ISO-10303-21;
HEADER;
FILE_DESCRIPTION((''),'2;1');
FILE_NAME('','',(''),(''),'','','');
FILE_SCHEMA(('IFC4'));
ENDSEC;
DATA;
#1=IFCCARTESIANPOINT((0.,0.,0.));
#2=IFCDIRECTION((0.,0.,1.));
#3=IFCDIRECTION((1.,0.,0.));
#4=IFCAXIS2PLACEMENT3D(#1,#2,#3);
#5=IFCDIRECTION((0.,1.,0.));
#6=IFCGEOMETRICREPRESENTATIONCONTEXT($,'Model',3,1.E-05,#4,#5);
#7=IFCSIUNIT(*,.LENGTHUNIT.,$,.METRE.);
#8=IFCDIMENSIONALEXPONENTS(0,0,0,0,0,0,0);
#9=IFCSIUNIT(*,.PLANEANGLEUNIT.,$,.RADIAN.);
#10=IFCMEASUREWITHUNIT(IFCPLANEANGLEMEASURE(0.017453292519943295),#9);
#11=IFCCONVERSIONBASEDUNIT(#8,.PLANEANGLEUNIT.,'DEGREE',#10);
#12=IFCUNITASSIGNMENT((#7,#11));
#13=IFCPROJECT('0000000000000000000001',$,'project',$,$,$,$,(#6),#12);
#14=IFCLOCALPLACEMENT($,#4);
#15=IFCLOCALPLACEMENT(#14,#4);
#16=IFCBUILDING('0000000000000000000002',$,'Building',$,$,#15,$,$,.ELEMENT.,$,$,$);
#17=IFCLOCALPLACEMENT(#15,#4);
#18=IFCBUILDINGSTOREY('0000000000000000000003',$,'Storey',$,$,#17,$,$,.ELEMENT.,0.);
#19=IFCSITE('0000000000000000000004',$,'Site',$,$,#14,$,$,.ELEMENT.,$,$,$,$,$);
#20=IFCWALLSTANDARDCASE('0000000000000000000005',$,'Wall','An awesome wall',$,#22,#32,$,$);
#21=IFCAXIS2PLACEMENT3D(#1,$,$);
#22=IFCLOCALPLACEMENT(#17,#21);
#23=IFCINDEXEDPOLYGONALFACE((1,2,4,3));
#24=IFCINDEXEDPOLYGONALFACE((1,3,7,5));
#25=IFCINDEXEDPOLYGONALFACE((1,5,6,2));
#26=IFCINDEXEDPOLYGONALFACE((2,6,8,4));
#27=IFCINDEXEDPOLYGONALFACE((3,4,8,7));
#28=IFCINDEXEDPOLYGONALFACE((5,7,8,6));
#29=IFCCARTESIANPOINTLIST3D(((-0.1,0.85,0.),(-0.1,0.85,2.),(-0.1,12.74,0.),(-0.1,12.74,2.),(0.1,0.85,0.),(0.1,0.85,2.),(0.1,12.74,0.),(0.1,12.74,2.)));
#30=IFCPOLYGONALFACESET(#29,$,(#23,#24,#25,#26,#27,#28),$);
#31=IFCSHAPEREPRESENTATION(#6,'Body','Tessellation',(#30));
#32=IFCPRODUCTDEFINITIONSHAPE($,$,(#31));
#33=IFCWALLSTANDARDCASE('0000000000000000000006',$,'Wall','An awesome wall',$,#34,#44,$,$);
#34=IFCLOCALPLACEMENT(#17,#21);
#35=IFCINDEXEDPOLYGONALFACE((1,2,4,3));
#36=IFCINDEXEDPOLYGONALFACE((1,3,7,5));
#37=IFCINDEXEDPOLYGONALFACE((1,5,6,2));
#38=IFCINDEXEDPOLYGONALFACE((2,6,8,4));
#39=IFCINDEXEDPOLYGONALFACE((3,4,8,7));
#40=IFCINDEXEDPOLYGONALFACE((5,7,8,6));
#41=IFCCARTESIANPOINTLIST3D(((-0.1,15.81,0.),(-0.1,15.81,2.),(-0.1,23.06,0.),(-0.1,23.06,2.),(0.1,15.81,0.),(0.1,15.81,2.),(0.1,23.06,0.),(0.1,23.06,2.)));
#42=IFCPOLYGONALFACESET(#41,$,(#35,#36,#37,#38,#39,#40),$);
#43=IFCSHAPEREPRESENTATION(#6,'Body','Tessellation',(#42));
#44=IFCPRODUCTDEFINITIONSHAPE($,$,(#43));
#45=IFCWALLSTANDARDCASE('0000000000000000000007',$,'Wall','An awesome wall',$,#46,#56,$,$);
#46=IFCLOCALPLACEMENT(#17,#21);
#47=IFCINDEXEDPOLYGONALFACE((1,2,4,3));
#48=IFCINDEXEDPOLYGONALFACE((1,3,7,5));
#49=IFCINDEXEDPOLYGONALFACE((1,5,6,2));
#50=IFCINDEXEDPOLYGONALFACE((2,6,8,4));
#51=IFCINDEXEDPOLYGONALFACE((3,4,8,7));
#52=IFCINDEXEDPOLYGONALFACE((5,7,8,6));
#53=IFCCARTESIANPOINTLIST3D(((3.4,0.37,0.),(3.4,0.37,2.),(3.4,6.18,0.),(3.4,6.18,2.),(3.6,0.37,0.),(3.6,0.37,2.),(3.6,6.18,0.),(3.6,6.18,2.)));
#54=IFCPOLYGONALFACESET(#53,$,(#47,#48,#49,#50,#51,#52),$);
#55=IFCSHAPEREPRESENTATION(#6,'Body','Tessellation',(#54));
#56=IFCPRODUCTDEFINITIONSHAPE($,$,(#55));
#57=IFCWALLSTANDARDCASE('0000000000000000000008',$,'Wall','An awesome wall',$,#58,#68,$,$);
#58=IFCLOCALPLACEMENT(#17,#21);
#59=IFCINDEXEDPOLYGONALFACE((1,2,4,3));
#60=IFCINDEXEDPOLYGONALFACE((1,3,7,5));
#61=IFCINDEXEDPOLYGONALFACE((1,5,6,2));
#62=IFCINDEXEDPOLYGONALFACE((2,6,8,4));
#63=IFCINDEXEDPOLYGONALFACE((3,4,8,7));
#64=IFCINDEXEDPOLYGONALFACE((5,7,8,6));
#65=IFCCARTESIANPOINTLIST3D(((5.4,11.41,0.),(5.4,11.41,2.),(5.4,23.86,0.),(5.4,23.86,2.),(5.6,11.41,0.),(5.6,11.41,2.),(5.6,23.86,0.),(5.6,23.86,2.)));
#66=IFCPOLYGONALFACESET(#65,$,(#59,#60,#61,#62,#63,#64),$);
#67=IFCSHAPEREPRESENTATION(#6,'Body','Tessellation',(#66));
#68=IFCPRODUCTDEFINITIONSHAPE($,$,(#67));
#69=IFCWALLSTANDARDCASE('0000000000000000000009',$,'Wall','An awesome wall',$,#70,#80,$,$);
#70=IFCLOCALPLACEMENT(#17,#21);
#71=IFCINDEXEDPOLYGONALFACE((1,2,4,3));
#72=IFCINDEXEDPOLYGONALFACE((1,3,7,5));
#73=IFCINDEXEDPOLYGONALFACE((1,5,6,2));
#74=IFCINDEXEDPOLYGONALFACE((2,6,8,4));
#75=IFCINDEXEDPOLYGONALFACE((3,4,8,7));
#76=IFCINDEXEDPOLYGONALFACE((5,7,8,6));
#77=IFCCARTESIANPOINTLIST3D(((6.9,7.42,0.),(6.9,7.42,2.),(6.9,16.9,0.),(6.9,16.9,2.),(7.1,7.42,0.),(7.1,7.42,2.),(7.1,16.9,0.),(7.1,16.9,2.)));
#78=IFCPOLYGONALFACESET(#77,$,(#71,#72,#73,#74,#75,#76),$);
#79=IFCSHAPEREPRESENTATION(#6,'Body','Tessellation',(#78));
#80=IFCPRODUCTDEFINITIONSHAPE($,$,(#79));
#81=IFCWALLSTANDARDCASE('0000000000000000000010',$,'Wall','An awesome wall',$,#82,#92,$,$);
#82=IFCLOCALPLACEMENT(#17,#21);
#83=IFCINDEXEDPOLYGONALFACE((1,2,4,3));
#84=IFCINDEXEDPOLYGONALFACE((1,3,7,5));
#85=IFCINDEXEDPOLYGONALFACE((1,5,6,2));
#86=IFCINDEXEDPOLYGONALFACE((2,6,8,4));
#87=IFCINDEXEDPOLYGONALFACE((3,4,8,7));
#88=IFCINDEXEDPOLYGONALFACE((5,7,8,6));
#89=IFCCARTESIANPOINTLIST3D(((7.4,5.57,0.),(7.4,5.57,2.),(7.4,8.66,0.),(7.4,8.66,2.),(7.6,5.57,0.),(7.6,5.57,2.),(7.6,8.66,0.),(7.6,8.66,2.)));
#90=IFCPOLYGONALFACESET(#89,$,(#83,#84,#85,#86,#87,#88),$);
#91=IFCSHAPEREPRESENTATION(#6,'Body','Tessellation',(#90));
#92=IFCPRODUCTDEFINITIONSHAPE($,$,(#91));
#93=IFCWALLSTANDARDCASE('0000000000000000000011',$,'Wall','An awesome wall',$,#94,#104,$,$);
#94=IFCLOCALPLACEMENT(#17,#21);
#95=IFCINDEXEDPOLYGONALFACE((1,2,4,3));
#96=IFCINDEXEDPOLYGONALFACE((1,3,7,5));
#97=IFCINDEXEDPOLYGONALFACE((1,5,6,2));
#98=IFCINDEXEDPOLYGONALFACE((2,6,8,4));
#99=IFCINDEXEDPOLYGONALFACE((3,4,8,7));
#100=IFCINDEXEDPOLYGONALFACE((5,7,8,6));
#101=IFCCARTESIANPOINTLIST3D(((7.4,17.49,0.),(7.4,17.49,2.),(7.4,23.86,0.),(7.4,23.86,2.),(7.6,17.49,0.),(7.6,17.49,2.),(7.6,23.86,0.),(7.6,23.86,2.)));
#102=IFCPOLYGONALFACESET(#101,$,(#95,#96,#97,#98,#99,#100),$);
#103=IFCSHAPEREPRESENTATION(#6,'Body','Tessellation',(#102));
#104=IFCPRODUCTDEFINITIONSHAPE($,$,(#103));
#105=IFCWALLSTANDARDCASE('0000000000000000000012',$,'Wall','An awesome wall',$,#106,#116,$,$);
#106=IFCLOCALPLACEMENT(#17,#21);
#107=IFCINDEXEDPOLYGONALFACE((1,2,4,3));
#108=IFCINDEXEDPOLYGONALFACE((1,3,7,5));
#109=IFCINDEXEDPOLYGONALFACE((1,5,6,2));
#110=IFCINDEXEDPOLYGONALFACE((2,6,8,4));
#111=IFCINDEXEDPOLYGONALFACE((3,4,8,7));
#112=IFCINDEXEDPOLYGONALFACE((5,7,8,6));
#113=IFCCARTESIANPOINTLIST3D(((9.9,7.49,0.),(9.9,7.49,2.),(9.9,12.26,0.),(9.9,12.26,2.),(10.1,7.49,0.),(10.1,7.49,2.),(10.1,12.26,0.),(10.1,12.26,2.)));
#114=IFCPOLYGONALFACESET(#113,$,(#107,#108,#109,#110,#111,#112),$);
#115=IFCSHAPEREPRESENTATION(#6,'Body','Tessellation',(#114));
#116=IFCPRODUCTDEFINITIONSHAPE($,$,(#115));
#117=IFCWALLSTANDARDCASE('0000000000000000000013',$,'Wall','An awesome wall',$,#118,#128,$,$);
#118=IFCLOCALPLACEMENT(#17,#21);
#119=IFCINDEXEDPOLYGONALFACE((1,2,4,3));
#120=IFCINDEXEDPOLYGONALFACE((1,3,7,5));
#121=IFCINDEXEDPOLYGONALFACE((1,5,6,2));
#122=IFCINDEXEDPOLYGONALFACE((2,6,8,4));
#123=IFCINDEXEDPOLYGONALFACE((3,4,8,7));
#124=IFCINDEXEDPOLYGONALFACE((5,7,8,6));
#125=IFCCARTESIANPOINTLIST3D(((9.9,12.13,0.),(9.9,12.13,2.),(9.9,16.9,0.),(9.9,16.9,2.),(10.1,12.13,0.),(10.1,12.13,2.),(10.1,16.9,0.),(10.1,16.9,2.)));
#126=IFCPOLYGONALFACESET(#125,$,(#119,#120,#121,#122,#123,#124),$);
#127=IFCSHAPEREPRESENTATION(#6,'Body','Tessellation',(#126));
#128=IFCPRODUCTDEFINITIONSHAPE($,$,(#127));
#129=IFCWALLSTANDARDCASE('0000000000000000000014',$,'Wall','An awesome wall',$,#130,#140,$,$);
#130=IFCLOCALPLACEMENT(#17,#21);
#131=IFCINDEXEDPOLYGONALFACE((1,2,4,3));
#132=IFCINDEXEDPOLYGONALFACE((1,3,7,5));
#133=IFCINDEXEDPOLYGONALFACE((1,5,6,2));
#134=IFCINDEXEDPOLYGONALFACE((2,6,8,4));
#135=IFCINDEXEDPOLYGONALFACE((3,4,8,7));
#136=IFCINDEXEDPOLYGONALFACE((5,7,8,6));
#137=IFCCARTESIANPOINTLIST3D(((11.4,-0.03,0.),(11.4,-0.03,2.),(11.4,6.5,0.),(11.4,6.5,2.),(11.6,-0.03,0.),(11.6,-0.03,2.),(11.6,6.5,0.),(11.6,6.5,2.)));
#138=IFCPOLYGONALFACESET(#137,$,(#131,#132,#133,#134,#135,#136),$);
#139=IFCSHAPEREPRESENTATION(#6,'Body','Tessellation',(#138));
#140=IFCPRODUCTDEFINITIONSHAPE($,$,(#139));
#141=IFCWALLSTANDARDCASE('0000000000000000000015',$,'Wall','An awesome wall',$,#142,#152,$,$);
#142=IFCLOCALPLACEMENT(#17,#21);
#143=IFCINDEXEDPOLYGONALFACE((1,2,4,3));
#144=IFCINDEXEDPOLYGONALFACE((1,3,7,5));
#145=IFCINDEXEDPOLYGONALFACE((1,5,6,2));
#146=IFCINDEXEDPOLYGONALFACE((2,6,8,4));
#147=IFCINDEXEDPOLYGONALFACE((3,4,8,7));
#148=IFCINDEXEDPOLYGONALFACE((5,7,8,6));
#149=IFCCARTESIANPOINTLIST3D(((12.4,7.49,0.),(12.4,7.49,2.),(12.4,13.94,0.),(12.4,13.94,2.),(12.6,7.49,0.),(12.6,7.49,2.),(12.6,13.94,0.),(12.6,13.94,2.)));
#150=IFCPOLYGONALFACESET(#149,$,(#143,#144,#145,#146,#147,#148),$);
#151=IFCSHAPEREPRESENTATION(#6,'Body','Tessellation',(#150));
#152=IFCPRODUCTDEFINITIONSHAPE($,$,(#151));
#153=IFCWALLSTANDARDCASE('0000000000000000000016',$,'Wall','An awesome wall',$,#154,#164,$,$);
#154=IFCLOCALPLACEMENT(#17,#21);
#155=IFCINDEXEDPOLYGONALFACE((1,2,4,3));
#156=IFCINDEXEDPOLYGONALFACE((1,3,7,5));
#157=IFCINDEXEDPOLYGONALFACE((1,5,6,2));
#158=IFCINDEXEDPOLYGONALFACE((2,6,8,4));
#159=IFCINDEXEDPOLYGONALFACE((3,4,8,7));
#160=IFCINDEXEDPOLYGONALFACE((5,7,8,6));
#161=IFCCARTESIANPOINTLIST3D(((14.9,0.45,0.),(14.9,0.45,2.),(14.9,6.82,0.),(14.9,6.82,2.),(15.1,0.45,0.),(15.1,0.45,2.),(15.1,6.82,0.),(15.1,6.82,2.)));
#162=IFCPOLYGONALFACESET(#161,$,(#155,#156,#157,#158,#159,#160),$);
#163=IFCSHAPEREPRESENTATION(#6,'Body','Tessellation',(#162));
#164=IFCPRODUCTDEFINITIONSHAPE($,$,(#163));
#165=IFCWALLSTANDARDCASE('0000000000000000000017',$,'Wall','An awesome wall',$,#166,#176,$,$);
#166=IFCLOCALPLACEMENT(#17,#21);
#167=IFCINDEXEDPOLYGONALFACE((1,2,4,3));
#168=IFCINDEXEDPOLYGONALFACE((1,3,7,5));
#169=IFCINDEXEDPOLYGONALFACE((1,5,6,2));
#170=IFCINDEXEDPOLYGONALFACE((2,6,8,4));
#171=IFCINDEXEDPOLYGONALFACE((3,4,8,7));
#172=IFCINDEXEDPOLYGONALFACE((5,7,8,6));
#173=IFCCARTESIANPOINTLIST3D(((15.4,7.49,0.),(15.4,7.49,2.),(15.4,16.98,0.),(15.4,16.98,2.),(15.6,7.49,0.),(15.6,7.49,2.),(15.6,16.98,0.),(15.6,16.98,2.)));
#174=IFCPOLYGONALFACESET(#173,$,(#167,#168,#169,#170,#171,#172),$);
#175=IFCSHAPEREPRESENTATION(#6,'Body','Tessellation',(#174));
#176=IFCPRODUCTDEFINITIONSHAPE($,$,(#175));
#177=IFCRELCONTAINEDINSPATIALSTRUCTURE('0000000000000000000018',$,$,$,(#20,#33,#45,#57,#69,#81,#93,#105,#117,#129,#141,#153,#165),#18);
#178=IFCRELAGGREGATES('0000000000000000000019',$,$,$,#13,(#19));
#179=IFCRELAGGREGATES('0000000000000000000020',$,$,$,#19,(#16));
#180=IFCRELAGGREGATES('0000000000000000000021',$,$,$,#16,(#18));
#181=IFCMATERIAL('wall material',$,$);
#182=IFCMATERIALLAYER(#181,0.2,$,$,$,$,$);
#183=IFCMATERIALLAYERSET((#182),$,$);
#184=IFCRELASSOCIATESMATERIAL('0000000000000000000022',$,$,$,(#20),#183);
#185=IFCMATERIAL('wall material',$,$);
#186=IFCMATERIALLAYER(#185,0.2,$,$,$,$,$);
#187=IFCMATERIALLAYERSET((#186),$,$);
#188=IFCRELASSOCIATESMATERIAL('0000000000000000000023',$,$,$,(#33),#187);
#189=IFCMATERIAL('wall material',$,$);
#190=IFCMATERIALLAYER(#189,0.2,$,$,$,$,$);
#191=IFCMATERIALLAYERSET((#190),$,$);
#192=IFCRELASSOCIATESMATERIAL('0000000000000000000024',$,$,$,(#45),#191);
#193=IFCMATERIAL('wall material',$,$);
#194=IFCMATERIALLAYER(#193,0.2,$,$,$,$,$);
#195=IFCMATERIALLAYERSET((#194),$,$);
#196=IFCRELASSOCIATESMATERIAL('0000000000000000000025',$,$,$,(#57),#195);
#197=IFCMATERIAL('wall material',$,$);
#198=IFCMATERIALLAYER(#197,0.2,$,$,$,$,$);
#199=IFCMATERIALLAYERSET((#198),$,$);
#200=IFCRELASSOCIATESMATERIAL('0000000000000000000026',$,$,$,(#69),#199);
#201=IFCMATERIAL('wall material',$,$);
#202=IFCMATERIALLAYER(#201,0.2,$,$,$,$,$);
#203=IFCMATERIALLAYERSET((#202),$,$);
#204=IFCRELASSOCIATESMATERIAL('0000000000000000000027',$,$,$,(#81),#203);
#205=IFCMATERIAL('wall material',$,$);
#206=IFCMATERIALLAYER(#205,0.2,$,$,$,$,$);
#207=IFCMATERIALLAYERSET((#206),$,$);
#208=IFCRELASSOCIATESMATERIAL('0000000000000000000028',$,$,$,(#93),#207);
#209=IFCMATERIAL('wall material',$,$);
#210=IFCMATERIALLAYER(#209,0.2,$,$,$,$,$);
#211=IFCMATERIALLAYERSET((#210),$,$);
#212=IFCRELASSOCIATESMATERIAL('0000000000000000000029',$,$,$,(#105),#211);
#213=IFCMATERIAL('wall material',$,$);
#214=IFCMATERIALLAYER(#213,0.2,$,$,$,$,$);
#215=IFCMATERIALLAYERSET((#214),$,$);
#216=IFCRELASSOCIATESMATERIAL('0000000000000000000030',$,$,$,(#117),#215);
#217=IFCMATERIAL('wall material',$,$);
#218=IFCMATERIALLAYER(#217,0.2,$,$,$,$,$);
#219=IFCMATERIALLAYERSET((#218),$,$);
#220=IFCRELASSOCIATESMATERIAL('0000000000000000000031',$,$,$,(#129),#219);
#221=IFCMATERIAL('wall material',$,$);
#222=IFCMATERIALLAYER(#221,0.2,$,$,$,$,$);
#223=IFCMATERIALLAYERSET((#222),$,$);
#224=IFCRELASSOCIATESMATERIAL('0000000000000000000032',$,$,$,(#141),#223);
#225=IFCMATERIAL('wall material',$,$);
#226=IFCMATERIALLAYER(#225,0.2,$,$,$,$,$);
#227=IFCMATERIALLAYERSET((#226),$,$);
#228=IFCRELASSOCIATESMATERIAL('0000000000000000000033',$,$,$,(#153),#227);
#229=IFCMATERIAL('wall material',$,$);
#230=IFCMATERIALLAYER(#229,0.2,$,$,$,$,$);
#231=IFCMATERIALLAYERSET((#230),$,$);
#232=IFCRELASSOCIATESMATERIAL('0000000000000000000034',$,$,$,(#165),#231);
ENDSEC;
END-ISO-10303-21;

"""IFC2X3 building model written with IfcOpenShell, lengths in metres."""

from ifc_helpers import new_model, entity, si_unit, converted_unit, direction, frame, origin_with_axes, place, context, project, spatial, polyline, outline, extrude, material, layer, layer_set, layer_usage, element, save


model = new_model("IFC2X3")

# Units and contexts
model_context = context("Model", 3, precision=1e-05, world=origin_with_axes(), true_north=direction((0.0, 1.0, 0.0)))
ifc_project = project(units=[si_unit("LENGTHUNIT", "METRE"), converted_unit("PLANEANGLEUNIT", "DEGREE", entity("IfcPlaneAngleMeasure", 0.017453292519943295), si_unit("PLANEANGLEUNIT", "RADIAN"), dimensions=[0, 0, 0, 0, 0, 0, 0])], contexts=[model_context])

# Site, building, storey
site_placement = place(None, origin_with_axes())
site = spatial("IfcSite", under=ifc_project, at=site_placement, Name="Site", CompositionType="ELEMENT")
building_placement = place(site_placement, origin_with_axes())
building = spatial("IfcBuilding", under=site, at=building_placement, Name="Building", CompositionType="ELEMENT")
storey_placement = place(building_placement, origin_with_axes())
storey = spatial("IfcBuildingStorey", under=building, at=storey_placement, Name="Storey", CompositionType="ELEMENT", Elevation=0.0)

# Walls
ifc_material_1 = material(Name="wall material")
ifc_layer_1 = layer(ifc_material_1, 0.2)
ifc_layer_set_1 = layer_set([ifc_layer_1])
ifc_layer_usage_1 = layer_usage(ifc_layer_set_1, "AXIS2", "POSITIVE", -0.1)
wall_1_placement = place(storey_placement, origin_with_axes())
element("IfcWallStandardCase", 1, at=wall_1_placement, inside=storey, material=ifc_layer_usage_1, Name="Wall", Description="An awesome wall", context=model_context, shape_type="SweptSolid", body=[
    extrude(outline(polyline([(0.0, -0.1, 0.0), (11.89, -0.1, 0.0), (11.89, 0.1, 0.0), (0.0, 0.1, 0.0), (0.0, -0.1, 0.0)])), frame((0.0, 0.85, 0.0), z_axis=(0.0, 0.0, 1.0), x_axis=(0.0, 1.0, 0.0)), (0.0, 0.0, 1.0), 2.0),
])
ifc_material_2 = material(Name="wall material")
ifc_layer_2 = layer(ifc_material_2, 0.2)
ifc_layer_set_2 = layer_set([ifc_layer_2])
ifc_layer_usage_2 = layer_usage(ifc_layer_set_2, "AXIS2", "POSITIVE", -0.1)
wall_2_placement = place(storey_placement, origin_with_axes())
element("IfcWallStandardCase", 2, at=wall_2_placement, inside=storey, material=ifc_layer_usage_2, Name="Wall", Description="An awesome wall", context=model_context, shape_type="SweptSolid", body=[
    extrude(outline(polyline([(0.0, -0.1, 0.0), (7.25, -0.1, 0.0), (7.25, 0.1, 0.0), (0.0, 0.1, 0.0), (0.0, -0.1, 0.0)])), frame((0.0, 15.81, 0.0), z_axis=(0.0, 0.0, 1.0), x_axis=(0.0, 1.0, 0.0)), (0.0, 0.0, 1.0), 2.0),
])
ifc_material_3 = material(Name="wall material")
ifc_layer_3 = layer(ifc_material_3, 0.2)
ifc_layer_set_3 = layer_set([ifc_layer_3])
ifc_layer_usage_3 = layer_usage(ifc_layer_set_3, "AXIS2", "POSITIVE", -0.1)
wall_3_placement = place(storey_placement, origin_with_axes())
element("IfcWallStandardCase", 3, at=wall_3_placement, inside=storey, material=ifc_layer_usage_3, Name="Wall", Description="An awesome wall", context=model_context, shape_type="SweptSolid", body=[
    extrude(outline(polyline([(0.0, -0.1, 0.0), (5.81, -0.1, 0.0), (5.81, 0.1, 0.0), (0.0, 0.1, 0.0), (0.0, -0.1, 0.0)])), frame((3.5, 0.37, 0.0), z_axis=(0.0, 0.0, 1.0), x_axis=(0.0, 1.0, 0.0)), (0.0, 0.0, 1.0), 2.0),
])
ifc_material_4 = material(Name="wall material")
ifc_layer_4 = layer(ifc_material_4, 0.2)
ifc_layer_set_4 = layer_set([ifc_layer_4])
ifc_layer_usage_4 = layer_usage(ifc_layer_set_4, "AXIS2", "POSITIVE", -0.1)
wall_4_placement = place(storey_placement, origin_with_axes())
element("IfcWallStandardCase", 4, at=wall_4_placement, inside=storey, material=ifc_layer_usage_4, Name="Wall", Description="An awesome wall", context=model_context, shape_type="SweptSolid", body=[
    extrude(outline(polyline([(0.0, -0.1, 0.0), (12.45, -0.1, 0.0), (12.45, 0.1, 0.0), (0.0, 0.1, 0.0), (0.0, -0.1, 0.0)])), frame((5.5, 11.41, 0.0), z_axis=(0.0, 0.0, 1.0), x_axis=(0.0, 1.0, 0.0)), (0.0, 0.0, 1.0), 2.0),
])
ifc_material_5 = material(Name="wall material")
ifc_layer_5 = layer(ifc_material_5, 0.2)
ifc_layer_set_5 = layer_set([ifc_layer_5])
ifc_layer_usage_5 = layer_usage(ifc_layer_set_5, "AXIS2", "POSITIVE", -0.1)
wall_5_placement = place(storey_placement, origin_with_axes())
element("IfcWallStandardCase", 5, at=wall_5_placement, inside=storey, material=ifc_layer_usage_5, Name="Wall", Description="An awesome wall", context=model_context, shape_type="SweptSolid", body=[
    extrude(outline(polyline([(0.0, -0.1, 0.0), (9.48, -0.1, 0.0), (9.48, 0.1, 0.0), (0.0, 0.1, 0.0), (0.0, -0.1, 0.0)])), frame((7.0, 7.42, 0.0), z_axis=(0.0, 0.0, 1.0), x_axis=(0.0, 1.0, 0.0)), (0.0, 0.0, 1.0), 2.0),
])
ifc_material_6 = material(Name="wall material")
ifc_layer_6 = layer(ifc_material_6, 0.2)
ifc_layer_set_6 = layer_set([ifc_layer_6])
ifc_layer_usage_6 = layer_usage(ifc_layer_set_6, "AXIS2", "POSITIVE", -0.1)
wall_6_placement = place(storey_placement, origin_with_axes())
element("IfcWallStandardCase", 6, at=wall_6_placement, inside=storey, material=ifc_layer_usage_6, Name="Wall", Description="An awesome wall", context=model_context, shape_type="SweptSolid", body=[
    extrude(outline(polyline([(0.0, -0.1, 0.0), (3.09, -0.1, 0.0), (3.09, 0.1, 0.0), (0.0, 0.1, 0.0), (0.0, -0.1, 0.0)])), frame((7.5, 5.57, 0.0), z_axis=(0.0, 0.0, 1.0), x_axis=(0.0, 1.0, 0.0)), (0.0, 0.0, 1.0), 2.0),
])
ifc_material_7 = material(Name="wall material")
ifc_layer_7 = layer(ifc_material_7, 0.2)
ifc_layer_set_7 = layer_set([ifc_layer_7])
ifc_layer_usage_7 = layer_usage(ifc_layer_set_7, "AXIS2", "POSITIVE", -0.1)
wall_7_placement = place(storey_placement, origin_with_axes())
element("IfcWallStandardCase", 7, at=wall_7_placement, inside=storey, material=ifc_layer_usage_7, Name="Wall", Description="An awesome wall", context=model_context, shape_type="SweptSolid", body=[
    extrude(outline(polyline([(0.0, -0.1, 0.0), (6.37, -0.1, 0.0), (6.37, 0.1, 0.0), (0.0, 0.1, 0.0), (0.0, -0.1, 0.0)])), frame((7.5, 17.49, 0.0), z_axis=(0.0, 0.0, 1.0), x_axis=(0.0, 1.0, 0.0)), (0.0, 0.0, 1.0), 2.0),
])
ifc_material_8 = material(Name="wall material")
ifc_layer_8 = layer(ifc_material_8, 0.2)
ifc_layer_set_8 = layer_set([ifc_layer_8])
ifc_layer_usage_8 = layer_usage(ifc_layer_set_8, "AXIS2", "POSITIVE", -0.1)
wall_8_placement = place(storey_placement, origin_with_axes())
element("IfcWallStandardCase", 8, at=wall_8_placement, inside=storey, material=ifc_layer_usage_8, Name="Wall", Description="An awesome wall", context=model_context, shape_type="SweptSolid", body=[
    extrude(outline(polyline([(0.0, -0.1, 0.0), (4.77, -0.1, 0.0), (4.77, 0.1, 0.0), (0.0, 0.1, 0.0), (0.0, -0.1, 0.0)])), frame((10.0, 7.49, 0.0), z_axis=(0.0, 0.0, 1.0), x_axis=(0.0, 1.0, 0.0)), (0.0, 0.0, 1.0), 2.0),
])
ifc_material_9 = material(Name="wall material")
ifc_layer_9 = layer(ifc_material_9, 0.2)
ifc_layer_set_9 = layer_set([ifc_layer_9])
ifc_layer_usage_9 = layer_usage(ifc_layer_set_9, "AXIS2", "POSITIVE", -0.1)
wall_9_placement = place(storey_placement, origin_with_axes())
element("IfcWallStandardCase", 9, at=wall_9_placement, inside=storey, material=ifc_layer_usage_9, Name="Wall", Description="An awesome wall", context=model_context, shape_type="SweptSolid", body=[
    extrude(outline(polyline([(0.0, -0.1, 0.0), (4.77, -0.1, 0.0), (4.77, 0.1, 0.0), (0.0, 0.1, 0.0), (0.0, -0.1, 0.0)])), frame((10.0, 12.13, 0.0), z_axis=(0.0, 0.0, 1.0), x_axis=(0.0, 1.0, 0.0)), (0.0, 0.0, 1.0), 2.0),
])
ifc_material_10 = material(Name="wall material")
ifc_layer_10 = layer(ifc_material_10, 0.2)
ifc_layer_set_10 = layer_set([ifc_layer_10])
ifc_layer_usage_10 = layer_usage(ifc_layer_set_10, "AXIS2", "POSITIVE", -0.1)
wall_10_placement = place(storey_placement, origin_with_axes())
element("IfcWallStandardCase", 10, at=wall_10_placement, inside=storey, material=ifc_layer_usage_10, Name="Wall", Description="An awesome wall", context=model_context, shape_type="SweptSolid", body=[
    extrude(outline(polyline([(0.0, -0.1, 0.0), (6.53, -0.1, 0.0), (6.53, 0.1, 0.0), (0.0, 0.1, 0.0), (0.0, -0.1, 0.0)])), frame((11.5, -0.03, 0.0), z_axis=(0.0, 0.0, 1.0), x_axis=(0.0, 1.0, 0.0)), (0.0, 0.0, 1.0), 2.0),
])
ifc_material_11 = material(Name="wall material")
ifc_layer_11 = layer(ifc_material_11, 0.2)
ifc_layer_set_11 = layer_set([ifc_layer_11])
ifc_layer_usage_11 = layer_usage(ifc_layer_set_11, "AXIS2", "POSITIVE", -0.1)
wall_11_placement = place(storey_placement, origin_with_axes())
element("IfcWallStandardCase", 11, at=wall_11_placement, inside=storey, material=ifc_layer_usage_11, Name="Wall", Description="An awesome wall", context=model_context, shape_type="SweptSolid", body=[
    extrude(outline(polyline([(0.0, -0.1, 0.0), (6.45, -0.1, 0.0), (6.45, 0.1, 0.0), (0.0, 0.1, 0.0), (0.0, -0.1, 0.0)])), frame((12.5, 7.49, 0.0), z_axis=(0.0, 0.0, 1.0), x_axis=(0.0, 1.0, 0.0)), (0.0, 0.0, 1.0), 2.0),
])
ifc_material_12 = material(Name="wall material")
ifc_layer_12 = layer(ifc_material_12, 0.2)
ifc_layer_set_12 = layer_set([ifc_layer_12])
ifc_layer_usage_12 = layer_usage(ifc_layer_set_12, "AXIS2", "POSITIVE", -0.1)
wall_12_placement = place(storey_placement, origin_with_axes())
element("IfcWallStandardCase", 12, at=wall_12_placement, inside=storey, material=ifc_layer_usage_12, Name="Wall", Description="An awesome wall", context=model_context, shape_type="SweptSolid", body=[
    extrude(outline(polyline([(0.0, -0.1, 0.0), (6.37, -0.1, 0.0), (6.37, 0.1, 0.0), (0.0, 0.1, 0.0), (0.0, -0.1, 0.0)])), frame((15.0, 0.45, 0.0), z_axis=(0.0, 0.0, 1.0), x_axis=(0.0, 1.0, 0.0)), (0.0, 0.0, 1.0), 2.0),
])
ifc_material_13 = material(Name="wall material")
ifc_layer_13 = layer(ifc_material_13, 0.2)
ifc_layer_set_13 = layer_set([ifc_layer_13])
ifc_layer_usage_13 = layer_usage(ifc_layer_set_13, "AXIS2", "POSITIVE", -0.1)
wall_13_placement = place(storey_placement, origin_with_axes())
element("IfcWallStandardCase", 13, at=wall_13_placement, inside=storey, material=ifc_layer_usage_13, Name="Wall", Description="An awesome wall", context=model_context, shape_type="SweptSolid", body=[
    extrude(outline(polyline([(0.0, -0.1, 0.0), (9.49, -0.1, 0.0), (9.49, 0.1, 0.0), (0.0, 0.1, 0.0), (0.0, -0.1, 0.0)])), frame((15.5, 7.49, 0.0), z_axis=(0.0, 0.0, 1.0), x_axis=(0.0, 1.0, 0.0)), (0.0, 0.0, 1.0), 2.0),
])

save(model, "model.ifc")
